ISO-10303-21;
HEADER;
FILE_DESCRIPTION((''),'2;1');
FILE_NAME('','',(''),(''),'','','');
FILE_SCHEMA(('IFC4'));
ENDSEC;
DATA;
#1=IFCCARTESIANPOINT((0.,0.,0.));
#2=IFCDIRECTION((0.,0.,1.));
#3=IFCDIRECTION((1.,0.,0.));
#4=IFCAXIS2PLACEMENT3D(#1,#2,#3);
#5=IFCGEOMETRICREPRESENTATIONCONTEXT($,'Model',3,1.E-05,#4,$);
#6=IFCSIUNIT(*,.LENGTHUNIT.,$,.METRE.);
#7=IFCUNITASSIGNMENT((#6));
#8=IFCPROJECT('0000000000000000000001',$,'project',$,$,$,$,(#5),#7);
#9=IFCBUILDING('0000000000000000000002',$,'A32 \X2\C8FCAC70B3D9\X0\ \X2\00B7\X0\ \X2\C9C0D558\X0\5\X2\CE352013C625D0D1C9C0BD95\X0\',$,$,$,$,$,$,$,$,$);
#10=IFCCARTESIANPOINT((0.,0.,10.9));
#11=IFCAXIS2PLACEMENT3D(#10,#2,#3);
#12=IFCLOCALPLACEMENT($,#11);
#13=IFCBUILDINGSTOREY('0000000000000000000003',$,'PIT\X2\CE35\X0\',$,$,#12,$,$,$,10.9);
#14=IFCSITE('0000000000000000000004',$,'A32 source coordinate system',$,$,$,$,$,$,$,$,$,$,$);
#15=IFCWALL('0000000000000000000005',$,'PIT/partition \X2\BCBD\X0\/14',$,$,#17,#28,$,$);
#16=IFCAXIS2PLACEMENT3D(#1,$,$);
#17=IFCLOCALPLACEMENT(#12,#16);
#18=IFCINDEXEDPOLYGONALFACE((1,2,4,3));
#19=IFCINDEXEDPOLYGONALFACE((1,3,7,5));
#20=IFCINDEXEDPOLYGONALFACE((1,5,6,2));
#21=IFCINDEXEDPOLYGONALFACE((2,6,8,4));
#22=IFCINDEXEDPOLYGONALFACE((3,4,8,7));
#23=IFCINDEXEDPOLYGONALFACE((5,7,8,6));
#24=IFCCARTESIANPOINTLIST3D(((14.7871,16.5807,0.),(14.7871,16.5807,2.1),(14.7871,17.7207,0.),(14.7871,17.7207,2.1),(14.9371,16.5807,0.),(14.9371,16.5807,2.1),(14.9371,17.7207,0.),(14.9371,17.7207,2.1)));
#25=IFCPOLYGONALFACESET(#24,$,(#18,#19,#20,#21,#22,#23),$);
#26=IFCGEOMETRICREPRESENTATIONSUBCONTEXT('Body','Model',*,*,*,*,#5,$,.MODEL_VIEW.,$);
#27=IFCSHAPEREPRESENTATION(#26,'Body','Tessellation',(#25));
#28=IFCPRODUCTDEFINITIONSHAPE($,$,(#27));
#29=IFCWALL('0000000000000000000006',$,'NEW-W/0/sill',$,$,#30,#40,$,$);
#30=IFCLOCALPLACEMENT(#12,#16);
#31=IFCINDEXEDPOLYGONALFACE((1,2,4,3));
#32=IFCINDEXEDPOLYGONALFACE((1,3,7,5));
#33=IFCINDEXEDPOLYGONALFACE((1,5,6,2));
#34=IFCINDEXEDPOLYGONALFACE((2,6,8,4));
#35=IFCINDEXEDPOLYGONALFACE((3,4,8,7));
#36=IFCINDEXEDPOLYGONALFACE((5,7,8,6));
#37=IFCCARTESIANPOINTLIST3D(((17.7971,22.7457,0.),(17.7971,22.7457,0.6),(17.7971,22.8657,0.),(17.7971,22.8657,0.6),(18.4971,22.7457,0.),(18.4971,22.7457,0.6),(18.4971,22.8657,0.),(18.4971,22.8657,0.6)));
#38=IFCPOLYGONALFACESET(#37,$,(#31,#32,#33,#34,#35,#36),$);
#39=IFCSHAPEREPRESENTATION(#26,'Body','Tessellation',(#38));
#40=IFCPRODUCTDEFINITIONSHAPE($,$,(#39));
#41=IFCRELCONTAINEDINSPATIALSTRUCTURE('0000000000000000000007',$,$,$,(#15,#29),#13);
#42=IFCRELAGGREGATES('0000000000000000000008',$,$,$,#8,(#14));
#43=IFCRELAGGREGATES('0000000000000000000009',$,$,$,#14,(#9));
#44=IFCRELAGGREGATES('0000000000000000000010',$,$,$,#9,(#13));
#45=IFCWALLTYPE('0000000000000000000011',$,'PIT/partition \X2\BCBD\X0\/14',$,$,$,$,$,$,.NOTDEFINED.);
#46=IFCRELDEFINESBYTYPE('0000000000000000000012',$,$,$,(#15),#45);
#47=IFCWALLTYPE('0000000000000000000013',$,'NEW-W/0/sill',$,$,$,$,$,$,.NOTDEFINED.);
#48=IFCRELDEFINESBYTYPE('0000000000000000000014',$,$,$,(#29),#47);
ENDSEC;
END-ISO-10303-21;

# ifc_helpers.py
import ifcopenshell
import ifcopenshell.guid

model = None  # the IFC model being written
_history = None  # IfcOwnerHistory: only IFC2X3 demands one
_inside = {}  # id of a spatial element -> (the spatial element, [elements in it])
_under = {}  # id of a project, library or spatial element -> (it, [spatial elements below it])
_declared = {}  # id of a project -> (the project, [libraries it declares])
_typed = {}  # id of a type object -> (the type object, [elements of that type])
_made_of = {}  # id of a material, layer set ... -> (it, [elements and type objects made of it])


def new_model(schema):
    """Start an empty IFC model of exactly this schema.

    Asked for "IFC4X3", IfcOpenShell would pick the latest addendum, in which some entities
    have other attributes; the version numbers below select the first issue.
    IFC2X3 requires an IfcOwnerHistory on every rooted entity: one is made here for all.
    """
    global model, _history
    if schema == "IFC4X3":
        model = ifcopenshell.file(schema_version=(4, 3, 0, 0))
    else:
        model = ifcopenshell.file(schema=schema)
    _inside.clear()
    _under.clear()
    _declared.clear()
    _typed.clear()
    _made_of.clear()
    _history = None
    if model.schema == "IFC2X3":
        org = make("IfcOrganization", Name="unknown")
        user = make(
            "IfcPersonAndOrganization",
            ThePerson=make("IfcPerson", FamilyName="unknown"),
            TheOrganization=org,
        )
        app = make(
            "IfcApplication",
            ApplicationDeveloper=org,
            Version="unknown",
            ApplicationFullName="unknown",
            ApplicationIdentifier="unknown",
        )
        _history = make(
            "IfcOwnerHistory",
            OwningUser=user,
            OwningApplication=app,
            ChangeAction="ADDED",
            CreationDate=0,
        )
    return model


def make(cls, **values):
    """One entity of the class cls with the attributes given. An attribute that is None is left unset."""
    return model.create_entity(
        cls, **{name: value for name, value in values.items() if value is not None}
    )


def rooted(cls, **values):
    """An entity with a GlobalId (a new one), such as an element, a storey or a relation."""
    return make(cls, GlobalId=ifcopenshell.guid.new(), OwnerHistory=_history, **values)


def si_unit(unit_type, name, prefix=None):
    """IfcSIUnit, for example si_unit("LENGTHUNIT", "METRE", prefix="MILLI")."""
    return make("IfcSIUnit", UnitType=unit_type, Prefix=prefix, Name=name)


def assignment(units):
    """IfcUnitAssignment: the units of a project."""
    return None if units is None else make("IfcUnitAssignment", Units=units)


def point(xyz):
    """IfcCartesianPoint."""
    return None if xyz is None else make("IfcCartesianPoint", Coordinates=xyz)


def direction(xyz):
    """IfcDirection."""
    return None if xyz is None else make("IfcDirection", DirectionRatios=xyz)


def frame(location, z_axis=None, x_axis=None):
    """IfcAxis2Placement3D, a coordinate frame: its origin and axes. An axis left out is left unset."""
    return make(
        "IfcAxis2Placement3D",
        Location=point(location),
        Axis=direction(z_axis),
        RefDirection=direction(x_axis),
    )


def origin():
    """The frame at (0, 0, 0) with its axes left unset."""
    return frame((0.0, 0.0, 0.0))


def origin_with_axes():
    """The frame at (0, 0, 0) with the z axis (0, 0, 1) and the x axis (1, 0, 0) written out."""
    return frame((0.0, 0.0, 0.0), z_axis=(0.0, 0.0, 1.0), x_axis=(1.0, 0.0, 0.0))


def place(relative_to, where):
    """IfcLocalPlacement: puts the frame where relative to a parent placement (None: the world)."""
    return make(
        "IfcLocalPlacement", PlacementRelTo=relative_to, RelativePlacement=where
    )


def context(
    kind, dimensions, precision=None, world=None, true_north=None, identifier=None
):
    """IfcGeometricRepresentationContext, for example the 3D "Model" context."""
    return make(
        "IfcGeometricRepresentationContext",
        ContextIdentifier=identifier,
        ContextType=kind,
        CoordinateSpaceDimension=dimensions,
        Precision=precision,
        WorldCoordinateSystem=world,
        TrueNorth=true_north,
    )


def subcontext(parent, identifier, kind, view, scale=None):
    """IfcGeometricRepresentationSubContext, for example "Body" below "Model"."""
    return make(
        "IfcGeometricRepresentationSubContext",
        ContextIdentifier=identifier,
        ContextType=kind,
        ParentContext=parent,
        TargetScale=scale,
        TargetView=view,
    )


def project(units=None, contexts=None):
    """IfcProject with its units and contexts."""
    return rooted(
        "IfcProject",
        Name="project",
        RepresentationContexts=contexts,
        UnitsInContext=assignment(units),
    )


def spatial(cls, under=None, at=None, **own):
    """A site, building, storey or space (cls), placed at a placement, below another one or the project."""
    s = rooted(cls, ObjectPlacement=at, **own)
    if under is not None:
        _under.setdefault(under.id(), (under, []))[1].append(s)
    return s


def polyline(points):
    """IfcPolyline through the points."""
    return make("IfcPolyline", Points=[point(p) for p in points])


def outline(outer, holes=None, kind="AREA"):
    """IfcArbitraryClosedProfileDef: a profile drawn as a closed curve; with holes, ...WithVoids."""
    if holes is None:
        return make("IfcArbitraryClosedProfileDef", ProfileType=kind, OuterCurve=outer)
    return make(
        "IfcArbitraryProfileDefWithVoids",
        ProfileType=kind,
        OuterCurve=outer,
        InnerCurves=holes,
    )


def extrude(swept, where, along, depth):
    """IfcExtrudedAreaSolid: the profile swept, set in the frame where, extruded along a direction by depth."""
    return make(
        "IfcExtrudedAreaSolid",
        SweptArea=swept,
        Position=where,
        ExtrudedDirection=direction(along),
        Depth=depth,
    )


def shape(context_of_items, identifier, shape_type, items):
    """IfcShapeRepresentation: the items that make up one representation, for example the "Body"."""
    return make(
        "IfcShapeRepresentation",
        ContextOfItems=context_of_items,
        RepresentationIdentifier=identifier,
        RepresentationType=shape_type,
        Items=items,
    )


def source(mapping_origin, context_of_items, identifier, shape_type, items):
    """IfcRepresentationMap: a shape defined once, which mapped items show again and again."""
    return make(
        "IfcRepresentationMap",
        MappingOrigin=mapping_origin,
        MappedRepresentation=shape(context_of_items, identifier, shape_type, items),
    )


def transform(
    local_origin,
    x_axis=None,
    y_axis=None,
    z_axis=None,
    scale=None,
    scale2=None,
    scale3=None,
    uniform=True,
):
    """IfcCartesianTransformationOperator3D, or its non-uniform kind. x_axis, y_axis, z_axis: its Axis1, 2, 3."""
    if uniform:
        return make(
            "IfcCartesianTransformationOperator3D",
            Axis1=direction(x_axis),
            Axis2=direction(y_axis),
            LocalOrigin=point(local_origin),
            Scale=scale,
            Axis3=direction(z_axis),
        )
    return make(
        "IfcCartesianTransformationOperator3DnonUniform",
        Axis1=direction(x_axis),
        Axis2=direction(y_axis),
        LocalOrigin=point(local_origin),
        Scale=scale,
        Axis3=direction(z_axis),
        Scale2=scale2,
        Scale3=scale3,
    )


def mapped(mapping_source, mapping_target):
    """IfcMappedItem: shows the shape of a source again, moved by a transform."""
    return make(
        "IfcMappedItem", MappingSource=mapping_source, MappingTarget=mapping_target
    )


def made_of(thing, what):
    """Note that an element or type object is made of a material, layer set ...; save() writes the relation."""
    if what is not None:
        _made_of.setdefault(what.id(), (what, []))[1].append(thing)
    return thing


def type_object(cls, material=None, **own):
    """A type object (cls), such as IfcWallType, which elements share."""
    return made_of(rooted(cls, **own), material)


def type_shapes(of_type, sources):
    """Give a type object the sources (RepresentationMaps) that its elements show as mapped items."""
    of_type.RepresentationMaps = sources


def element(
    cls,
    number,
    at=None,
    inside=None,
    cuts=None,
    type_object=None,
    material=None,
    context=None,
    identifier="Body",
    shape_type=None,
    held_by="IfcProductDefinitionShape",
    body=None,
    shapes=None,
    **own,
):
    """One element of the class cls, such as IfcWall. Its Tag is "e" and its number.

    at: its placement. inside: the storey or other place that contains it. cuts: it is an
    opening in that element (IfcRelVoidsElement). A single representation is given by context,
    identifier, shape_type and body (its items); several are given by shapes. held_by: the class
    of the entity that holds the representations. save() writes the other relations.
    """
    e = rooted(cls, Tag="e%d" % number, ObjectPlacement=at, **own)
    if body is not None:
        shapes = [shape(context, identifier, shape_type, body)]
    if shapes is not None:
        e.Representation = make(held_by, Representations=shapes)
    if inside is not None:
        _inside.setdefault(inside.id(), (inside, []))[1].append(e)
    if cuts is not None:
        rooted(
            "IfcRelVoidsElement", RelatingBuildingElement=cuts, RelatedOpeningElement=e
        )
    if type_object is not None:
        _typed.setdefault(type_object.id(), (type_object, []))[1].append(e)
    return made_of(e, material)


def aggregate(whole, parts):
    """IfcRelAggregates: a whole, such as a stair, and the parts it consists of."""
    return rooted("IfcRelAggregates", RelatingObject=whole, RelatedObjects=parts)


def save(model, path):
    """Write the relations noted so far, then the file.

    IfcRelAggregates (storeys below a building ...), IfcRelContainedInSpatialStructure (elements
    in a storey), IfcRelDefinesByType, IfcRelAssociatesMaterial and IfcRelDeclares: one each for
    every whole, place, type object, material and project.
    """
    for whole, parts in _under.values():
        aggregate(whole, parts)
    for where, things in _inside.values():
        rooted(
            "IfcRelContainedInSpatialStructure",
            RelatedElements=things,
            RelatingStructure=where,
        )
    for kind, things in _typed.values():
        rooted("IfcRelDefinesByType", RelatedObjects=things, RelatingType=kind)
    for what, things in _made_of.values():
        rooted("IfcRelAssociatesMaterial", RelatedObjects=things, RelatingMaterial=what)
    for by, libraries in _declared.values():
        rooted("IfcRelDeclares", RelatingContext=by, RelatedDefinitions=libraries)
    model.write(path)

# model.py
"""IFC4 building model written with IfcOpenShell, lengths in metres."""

from ifc_helpers import new_model, si_unit, frame, origin, origin_with_axes, place, context, subcontext, project, spatial, polyline, outline, extrude, source, transform, mapped, type_object, type_shapes, element, save


model = new_model("IFC4")

# Units and contexts
model_context = context("Model", 3, precision=1e-05, world=origin_with_axes())
body_context = subcontext(model_context, "Body", "Model", "MODEL_VIEW")
ifc_project = project(units=[si_unit("LENGTHUNIT", "METRE")], contexts=[model_context])

# Site, building, storey
site = spatial("IfcSite", under=ifc_project, Name="A32 source coordinate system")
building = spatial("IfcBuilding", under=site, Name="A32 주거동 · 지하5층–옥탑지붕")
storey_placement = place(None, frame((0.0, 0.0, 10.9), z_axis=(0.0, 0.0, 1.0), x_axis=(1.0, 0.0, 0.0)))
storey = spatial("IfcBuildingStorey", under=building, at=storey_placement, Name="PIT층", Elevation=10.9)

# Walls
wall_type_1 = type_object("IfcWallType", Name="PIT/partition 벽/14", PredefinedType="NOTDEFINED")
shared_shape_1 = source(origin(), body_context, "Body", "SweptSolid", [
    extrude(outline(polyline([(14.7871, 16.5807), (14.7871, 17.7207), (14.9371, 17.7207), (14.9371, 16.5807), (14.7871, 16.5807)])), origin(), (0.0, 0.0, 1.0), 2.1),
])
type_shapes(wall_type_1, [shared_shape_1])
wall_1_placement = place(storey_placement, origin_with_axes())
element("IfcWall", 1, at=wall_1_placement, inside=storey, type_object=wall_type_1, Name="PIT/partition 벽/14", context=body_context, shape_type="MappedRepresentation", body=[
    mapped(shared_shape_1, transform((0.0, 0.0, 0.0), scale=1.0)),
])
wall_type_2 = type_object("IfcWallType", Name="NEW-W/0/sill", PredefinedType="NOTDEFINED")
shared_shape_2 = source(origin(), body_context, "Body", "SweptSolid", [
    extrude(outline(polyline([(17.7971, 22.7457), (17.7971, 22.8657), (18.4971, 22.8657), (18.4971, 22.7457), (17.7971, 22.7457)])), origin(), (0.0, 0.0, 1.0), 0.6),
])
type_shapes(wall_type_2, [shared_shape_2])
wall_2_placement = place(storey_placement, origin_with_axes())
element("IfcWall", 2, at=wall_2_placement, inside=storey, type_object=wall_type_2, Name="NEW-W/0/sill", context=body_context, shape_type="MappedRepresentation", body=[
    mapped(shared_shape_2, transform((0.0, 0.0, 0.0), scale=1.0)),
])

save(model, "model.ifc")
